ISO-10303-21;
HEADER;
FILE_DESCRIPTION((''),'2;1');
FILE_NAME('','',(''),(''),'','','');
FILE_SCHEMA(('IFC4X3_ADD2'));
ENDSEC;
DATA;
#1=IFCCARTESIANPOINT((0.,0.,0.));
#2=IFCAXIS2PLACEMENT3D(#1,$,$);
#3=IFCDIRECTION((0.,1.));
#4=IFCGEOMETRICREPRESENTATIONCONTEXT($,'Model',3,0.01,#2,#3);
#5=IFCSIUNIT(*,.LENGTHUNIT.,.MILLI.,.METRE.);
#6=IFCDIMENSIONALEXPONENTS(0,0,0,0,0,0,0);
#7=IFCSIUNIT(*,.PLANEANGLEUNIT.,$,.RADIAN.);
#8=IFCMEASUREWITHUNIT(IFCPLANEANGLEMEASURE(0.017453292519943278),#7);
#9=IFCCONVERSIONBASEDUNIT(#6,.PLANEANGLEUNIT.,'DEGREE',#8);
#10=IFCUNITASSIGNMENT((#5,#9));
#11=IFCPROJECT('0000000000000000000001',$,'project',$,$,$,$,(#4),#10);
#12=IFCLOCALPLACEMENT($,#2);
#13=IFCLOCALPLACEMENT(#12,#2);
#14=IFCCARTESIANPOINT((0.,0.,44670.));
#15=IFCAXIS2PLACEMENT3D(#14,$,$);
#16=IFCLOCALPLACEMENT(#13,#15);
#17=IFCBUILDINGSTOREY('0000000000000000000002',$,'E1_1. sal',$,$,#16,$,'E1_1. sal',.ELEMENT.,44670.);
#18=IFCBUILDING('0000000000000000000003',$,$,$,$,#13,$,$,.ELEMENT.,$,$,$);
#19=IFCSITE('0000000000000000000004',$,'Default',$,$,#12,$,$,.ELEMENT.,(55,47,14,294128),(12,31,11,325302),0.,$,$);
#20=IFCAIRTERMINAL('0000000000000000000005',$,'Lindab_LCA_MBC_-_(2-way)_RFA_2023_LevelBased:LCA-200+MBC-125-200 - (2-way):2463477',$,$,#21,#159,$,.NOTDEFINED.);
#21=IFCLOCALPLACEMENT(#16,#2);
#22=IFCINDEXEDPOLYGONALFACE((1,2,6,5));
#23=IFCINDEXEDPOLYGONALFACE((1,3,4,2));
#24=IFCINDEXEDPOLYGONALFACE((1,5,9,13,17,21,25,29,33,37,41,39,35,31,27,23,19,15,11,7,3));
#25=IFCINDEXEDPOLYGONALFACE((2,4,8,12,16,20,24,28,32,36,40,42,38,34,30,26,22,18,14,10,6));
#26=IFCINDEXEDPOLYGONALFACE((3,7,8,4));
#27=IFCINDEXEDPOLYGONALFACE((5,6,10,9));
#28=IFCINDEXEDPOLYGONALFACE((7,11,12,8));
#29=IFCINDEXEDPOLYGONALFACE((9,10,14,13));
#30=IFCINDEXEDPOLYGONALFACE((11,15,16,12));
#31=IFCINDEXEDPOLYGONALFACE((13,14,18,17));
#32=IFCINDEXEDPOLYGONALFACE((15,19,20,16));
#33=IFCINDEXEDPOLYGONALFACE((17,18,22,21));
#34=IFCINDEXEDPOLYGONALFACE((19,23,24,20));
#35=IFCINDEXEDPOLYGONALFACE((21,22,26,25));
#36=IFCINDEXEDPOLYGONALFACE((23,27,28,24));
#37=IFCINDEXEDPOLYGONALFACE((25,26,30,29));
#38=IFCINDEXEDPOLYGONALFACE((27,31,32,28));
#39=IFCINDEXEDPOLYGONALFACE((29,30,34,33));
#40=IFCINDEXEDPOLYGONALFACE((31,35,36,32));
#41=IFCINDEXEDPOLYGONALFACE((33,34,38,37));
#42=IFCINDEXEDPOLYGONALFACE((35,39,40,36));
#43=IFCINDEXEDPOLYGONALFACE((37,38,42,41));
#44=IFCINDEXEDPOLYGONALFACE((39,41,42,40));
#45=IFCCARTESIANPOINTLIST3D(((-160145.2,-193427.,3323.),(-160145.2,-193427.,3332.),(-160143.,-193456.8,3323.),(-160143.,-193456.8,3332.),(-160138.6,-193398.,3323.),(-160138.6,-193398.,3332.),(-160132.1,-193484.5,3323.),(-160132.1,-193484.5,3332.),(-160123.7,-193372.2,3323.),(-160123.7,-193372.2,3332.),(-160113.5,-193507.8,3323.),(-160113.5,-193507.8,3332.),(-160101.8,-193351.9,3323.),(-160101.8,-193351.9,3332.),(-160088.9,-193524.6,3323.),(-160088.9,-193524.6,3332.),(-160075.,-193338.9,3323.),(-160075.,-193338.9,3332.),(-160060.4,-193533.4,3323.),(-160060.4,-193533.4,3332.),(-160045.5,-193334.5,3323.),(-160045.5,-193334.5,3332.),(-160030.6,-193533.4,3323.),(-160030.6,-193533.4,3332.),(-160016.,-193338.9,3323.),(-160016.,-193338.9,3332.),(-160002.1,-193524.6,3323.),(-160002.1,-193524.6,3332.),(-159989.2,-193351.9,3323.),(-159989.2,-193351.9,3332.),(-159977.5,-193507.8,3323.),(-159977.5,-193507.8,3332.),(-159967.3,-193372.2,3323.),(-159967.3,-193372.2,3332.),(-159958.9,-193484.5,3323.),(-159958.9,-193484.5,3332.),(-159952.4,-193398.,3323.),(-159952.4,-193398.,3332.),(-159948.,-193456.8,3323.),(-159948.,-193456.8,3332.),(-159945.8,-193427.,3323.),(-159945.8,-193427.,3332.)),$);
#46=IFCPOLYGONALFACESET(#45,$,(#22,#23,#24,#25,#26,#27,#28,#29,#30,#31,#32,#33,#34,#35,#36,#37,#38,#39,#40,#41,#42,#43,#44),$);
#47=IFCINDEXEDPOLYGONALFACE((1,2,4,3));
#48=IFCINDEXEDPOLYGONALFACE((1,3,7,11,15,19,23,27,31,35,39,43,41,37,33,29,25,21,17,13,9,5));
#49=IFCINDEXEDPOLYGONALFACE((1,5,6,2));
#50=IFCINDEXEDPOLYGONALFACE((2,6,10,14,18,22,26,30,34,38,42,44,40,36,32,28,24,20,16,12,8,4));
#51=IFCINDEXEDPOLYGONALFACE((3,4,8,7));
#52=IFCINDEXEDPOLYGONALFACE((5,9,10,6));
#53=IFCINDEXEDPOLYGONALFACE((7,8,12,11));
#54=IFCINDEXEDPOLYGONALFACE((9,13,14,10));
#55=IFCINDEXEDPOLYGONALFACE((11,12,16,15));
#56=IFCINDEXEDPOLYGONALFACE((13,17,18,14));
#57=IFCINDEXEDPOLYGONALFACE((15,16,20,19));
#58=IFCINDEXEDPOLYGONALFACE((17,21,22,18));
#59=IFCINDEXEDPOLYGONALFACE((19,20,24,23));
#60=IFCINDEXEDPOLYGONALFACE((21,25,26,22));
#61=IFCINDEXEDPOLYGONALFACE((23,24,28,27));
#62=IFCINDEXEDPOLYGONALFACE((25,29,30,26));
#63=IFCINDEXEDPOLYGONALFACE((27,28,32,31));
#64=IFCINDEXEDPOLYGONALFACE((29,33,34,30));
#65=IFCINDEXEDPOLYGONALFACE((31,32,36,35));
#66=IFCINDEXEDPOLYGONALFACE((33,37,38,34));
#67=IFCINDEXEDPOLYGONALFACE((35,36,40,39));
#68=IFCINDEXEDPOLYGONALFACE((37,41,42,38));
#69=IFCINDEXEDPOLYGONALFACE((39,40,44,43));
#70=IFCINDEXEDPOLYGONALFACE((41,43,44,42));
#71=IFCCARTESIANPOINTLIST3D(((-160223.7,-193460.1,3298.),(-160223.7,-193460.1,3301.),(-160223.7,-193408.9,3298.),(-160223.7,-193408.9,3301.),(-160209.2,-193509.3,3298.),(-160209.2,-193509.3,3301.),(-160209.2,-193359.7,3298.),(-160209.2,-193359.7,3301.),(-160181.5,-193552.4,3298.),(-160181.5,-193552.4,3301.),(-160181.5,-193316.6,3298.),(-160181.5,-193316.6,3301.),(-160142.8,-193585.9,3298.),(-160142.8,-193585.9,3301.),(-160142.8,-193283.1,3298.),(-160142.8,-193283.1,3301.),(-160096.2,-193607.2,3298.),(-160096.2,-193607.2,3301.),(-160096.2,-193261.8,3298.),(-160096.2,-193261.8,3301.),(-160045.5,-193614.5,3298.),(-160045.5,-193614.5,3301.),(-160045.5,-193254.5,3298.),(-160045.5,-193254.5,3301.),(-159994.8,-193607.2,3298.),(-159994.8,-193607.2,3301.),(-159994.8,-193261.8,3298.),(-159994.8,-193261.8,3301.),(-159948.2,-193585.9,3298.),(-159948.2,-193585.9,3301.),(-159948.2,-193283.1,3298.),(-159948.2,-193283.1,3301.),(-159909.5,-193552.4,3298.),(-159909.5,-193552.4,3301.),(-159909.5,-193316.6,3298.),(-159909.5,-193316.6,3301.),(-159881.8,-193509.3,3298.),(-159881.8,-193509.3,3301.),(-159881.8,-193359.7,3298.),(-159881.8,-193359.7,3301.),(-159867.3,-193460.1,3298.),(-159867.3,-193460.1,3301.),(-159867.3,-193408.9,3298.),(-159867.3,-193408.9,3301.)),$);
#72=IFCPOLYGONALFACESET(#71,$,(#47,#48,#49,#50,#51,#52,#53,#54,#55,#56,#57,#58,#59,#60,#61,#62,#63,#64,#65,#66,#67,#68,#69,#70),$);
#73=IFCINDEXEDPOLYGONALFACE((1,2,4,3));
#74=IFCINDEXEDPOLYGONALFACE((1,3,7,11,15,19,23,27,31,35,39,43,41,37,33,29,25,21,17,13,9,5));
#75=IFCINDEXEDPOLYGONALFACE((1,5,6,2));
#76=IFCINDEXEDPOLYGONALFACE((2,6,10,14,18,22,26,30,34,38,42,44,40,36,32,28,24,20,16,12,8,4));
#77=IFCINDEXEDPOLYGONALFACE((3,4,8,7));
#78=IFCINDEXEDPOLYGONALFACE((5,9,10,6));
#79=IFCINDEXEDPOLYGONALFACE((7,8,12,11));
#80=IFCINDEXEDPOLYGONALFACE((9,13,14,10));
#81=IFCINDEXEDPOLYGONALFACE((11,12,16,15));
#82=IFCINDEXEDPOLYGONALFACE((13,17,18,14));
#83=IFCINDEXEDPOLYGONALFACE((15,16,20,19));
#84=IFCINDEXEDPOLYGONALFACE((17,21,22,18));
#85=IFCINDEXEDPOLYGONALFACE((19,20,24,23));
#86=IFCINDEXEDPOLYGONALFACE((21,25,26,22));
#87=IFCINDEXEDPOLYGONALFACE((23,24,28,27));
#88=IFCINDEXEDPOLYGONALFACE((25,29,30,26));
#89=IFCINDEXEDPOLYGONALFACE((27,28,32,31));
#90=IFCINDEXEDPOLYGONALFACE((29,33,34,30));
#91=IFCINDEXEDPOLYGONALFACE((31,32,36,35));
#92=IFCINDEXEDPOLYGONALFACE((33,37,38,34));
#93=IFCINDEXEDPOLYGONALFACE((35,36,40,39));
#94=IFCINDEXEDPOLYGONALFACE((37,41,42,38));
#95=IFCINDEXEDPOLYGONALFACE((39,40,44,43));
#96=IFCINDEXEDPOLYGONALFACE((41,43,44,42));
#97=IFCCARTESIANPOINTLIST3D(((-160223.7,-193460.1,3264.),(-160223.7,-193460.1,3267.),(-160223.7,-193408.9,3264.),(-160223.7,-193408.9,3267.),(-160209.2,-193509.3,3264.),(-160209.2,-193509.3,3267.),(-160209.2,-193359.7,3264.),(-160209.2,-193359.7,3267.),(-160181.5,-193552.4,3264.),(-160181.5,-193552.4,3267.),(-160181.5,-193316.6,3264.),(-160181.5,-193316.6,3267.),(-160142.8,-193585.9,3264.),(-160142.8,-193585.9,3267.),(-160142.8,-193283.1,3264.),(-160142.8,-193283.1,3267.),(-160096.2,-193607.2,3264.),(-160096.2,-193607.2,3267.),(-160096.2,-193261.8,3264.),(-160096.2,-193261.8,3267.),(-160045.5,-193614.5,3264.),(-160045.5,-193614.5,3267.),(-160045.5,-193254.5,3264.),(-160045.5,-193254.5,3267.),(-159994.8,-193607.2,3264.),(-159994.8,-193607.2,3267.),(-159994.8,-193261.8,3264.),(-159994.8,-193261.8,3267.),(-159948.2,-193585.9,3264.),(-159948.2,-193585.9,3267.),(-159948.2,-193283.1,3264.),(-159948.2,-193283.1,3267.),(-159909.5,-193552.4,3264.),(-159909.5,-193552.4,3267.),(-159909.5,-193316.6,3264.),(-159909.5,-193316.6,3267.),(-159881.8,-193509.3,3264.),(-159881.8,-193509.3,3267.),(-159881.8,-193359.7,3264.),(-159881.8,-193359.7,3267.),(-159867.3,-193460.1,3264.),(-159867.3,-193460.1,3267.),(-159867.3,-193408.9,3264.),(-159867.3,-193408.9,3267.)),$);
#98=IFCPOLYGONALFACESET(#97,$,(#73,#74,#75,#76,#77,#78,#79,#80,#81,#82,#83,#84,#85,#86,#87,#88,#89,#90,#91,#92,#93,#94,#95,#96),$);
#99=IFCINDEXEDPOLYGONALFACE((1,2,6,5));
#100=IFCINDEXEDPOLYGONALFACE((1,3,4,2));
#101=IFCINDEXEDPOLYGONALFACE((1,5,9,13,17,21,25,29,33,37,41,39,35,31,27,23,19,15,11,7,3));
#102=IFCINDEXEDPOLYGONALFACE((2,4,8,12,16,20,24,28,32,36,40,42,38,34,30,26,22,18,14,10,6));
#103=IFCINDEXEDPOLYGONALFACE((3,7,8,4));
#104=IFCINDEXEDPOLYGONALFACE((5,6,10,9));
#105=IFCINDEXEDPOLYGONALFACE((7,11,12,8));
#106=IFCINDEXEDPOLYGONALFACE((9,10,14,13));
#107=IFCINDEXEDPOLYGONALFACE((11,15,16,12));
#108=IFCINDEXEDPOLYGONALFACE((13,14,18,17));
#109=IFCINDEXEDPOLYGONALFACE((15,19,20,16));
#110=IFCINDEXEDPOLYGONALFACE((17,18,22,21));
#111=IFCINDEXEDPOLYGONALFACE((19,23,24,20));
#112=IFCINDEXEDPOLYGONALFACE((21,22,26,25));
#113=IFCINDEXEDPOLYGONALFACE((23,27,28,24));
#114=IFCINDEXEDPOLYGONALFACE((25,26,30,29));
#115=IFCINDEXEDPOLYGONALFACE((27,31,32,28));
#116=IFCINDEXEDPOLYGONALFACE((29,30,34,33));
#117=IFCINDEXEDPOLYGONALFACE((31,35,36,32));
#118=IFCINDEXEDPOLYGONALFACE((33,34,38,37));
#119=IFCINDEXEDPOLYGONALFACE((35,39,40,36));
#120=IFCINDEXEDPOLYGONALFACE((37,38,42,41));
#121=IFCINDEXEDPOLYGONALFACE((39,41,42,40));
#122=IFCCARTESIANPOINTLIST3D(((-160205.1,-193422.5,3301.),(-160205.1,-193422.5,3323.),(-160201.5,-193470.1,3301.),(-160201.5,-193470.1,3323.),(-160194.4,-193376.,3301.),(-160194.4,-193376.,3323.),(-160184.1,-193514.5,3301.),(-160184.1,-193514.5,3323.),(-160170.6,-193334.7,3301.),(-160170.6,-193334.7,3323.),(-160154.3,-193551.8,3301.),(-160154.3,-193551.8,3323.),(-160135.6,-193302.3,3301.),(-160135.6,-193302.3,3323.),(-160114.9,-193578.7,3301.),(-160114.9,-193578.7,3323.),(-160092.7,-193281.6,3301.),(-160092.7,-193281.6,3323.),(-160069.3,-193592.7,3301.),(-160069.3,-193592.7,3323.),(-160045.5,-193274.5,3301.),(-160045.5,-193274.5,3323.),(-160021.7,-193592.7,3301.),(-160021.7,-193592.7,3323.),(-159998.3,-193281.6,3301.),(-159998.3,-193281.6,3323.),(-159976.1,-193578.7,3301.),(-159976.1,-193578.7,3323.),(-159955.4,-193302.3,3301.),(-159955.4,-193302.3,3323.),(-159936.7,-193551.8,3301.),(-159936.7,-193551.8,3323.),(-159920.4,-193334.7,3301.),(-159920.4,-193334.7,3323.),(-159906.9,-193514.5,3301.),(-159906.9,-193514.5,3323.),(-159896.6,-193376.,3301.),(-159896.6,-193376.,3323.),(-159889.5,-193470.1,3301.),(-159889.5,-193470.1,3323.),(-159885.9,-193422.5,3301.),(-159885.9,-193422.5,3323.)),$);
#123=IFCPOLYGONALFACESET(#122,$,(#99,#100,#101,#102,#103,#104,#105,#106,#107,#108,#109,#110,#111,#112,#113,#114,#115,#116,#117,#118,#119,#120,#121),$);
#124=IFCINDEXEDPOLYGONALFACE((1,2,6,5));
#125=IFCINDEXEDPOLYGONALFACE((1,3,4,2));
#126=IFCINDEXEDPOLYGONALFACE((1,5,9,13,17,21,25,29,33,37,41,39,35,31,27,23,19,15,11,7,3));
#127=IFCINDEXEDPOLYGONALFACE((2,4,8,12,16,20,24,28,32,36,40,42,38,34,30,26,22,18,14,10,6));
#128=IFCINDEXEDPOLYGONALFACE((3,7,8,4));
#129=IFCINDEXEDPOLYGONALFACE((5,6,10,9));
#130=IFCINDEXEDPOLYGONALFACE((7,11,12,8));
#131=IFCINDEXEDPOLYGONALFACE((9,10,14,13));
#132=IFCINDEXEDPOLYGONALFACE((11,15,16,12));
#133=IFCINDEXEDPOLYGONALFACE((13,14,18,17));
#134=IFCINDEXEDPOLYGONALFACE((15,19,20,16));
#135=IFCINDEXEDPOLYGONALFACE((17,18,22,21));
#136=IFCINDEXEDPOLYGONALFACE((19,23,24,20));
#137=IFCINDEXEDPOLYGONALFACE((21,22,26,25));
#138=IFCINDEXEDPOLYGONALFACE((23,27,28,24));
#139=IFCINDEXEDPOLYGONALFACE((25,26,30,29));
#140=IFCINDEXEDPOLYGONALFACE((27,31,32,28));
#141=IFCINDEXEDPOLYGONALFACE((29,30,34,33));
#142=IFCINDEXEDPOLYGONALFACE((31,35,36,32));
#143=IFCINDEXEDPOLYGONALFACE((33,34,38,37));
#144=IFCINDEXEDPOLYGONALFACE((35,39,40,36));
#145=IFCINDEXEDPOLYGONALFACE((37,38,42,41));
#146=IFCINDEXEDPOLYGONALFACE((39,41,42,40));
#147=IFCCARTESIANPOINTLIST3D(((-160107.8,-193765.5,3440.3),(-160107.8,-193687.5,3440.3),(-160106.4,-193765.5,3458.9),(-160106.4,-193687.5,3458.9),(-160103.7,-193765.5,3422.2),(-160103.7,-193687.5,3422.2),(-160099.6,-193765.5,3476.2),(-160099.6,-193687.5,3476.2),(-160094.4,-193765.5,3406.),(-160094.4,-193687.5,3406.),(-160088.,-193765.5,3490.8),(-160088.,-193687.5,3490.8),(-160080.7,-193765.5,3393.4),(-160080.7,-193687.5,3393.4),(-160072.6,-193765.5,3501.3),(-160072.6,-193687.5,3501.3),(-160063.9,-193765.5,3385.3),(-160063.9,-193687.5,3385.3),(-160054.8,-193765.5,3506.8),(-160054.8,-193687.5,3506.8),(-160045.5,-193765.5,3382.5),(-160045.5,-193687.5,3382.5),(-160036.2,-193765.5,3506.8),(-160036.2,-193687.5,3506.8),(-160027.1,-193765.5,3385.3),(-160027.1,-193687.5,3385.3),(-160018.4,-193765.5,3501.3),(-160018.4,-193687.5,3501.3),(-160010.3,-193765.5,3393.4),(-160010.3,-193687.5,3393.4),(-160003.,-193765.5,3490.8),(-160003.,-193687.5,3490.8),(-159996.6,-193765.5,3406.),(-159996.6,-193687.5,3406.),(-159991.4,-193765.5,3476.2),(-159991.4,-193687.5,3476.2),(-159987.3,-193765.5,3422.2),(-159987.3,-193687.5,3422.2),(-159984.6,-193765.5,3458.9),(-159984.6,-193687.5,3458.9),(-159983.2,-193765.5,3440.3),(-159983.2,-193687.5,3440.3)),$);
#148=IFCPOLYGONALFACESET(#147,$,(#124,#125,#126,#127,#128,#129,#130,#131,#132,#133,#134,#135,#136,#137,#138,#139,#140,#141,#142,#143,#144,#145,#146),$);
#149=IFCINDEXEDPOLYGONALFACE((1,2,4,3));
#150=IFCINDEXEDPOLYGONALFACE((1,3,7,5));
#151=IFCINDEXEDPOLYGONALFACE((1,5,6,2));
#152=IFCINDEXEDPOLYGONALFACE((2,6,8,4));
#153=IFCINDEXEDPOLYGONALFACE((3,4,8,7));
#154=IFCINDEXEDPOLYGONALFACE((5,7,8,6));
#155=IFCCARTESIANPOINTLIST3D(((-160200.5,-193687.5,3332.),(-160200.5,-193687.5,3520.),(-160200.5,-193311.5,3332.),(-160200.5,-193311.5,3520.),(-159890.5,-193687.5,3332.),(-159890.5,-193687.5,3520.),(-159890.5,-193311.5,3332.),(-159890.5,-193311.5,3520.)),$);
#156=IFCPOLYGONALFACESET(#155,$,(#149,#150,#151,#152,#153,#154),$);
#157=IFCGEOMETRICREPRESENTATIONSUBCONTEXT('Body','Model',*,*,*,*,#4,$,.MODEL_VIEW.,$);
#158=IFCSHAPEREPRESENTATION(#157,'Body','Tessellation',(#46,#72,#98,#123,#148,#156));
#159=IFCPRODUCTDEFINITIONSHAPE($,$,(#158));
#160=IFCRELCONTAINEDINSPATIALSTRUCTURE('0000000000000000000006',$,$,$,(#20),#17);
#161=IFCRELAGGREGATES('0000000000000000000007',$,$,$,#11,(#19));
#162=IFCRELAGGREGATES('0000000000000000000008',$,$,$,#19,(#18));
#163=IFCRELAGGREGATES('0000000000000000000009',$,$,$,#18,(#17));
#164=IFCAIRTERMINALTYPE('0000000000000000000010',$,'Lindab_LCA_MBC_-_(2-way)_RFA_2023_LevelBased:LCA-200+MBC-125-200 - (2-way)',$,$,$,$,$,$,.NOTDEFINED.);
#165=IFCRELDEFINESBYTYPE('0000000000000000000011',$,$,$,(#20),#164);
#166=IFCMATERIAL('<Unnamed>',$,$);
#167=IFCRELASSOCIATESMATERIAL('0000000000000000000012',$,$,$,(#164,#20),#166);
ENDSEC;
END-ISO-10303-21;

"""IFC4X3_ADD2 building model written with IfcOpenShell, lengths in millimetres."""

from ifc_helpers import new_model, entity, si_unit, converted_unit, direction, frame, frame_2d, origin, origin_2d_with_axis, place, context, subcontext, project, spatial, rectangle, circle, extrude, source, transform, mapped, material, type_object, type_shapes, element, save


model = new_model("IFC4X3_ADD2")

# Units and contexts
model_context = context("Model", 3, precision=0.01, world=origin(), true_north=direction((0.0, 1.0)))
body_context = subcontext(model_context, "Body", "Model", "MODEL_VIEW")
ifc_project = project(units=[si_unit("LENGTHUNIT", "METRE", prefix="MILLI"), converted_unit("PLANEANGLEUNIT", "DEGREE", entity("IfcPlaneAngleMeasure", 0.017453292519943278), si_unit("PLANEANGLEUNIT", "RADIAN"), dimensions=[0, 0, 0, 0, 0, 0, 0])], contexts=[model_context])

# Site, building, storey
site_placement = place(None, origin())
site = spatial("IfcSite", under=ifc_project, at=site_placement, Name="Default", CompositionType="ELEMENT", RefLatitude=(55, 47, 14, 294128), RefLongitude=(12, 31, 11, 325302), RefElevation=0.0)
building_placement = place(site_placement, origin())
building = spatial("IfcBuilding", under=site, at=building_placement, CompositionType="ELEMENT")
storey_placement = place(building_placement, frame((0.0, 0.0, 44670.0)))
storey = spatial("IfcBuildingStorey", under=building, at=storey_placement, Name="E1_1. sal", LongName="E1_1. sal", CompositionType="ELEMENT", Elevation=44670.0)

# Air terminal
ifc_material_1 = material(Name="<Unnamed>")
air_terminal_type_1 = type_object("IfcAirTerminalType", Name="Lindab_LCA_MBC_-_(2-way)_RFA_2023_LevelBased:LCA-200+MBC-125-200 - (2-way)", PredefinedType="NOTDEFINED", material=ifc_material_1)
shared_shape_1 = source(origin(), body_context, "Body", "SweptSolid", [
    extrude(circle(Radius=100.0, at=frame_2d((0.0, 0.0), x_axis=(1.0, 0.0))), frame((0.0, 0.0, 22.0)), (0.0, 0.0, 1.0), 9.0),
    extrude(circle(Radius=180.0, at=frame_2d((0.0, 0.0), x_axis=(1.0, 0.0))), frame((0.0, 0.0, -3.0)), (0.0, 0.0, 1.0), 3.0),
    extrude(circle(Radius=180.0, at=frame_2d((0.0, 0.0), x_axis=(1.0, 0.0))), frame((0.0, 0.0, -37.0)), (0.0, 0.0, 1.0), 3.0),
    extrude(circle(Radius=160.0, at=frame_2d((0.0, 0.0), x_axis=(1.0, 0.0))), origin(), (0.0, 0.0, 1.0), 22.0),
    extrude(circle(Radius=62.5, at=frame_2d((0.0, 0.0), x_axis=(1.0, 0.0))), frame((-331.0, 0.0, 144.0), z_axis=(1.0, 0.0, 0.0), x_axis=(0.0, 0.0, -1.0)), (0.0, 0.0, 1.0), 78.0),
    extrude(rectangle(XDim=310.0, YDim=376.0, at=origin_2d_with_axis()), frame((-65.0, 0.0, 31.0), z_axis=(0.0, 0.0, 1.0), x_axis=(0.0, -1.0, 0.0)), (0.0, 0.0, 1.0), 188.0),
])
type_shapes(air_terminal_type_1, [shared_shape_1])
for number, where, z_axis, x_axis, name in (
    (1, (-160045.5, -193434.5, 3301.0), (0.0, 0.0, 1.0), (0.0, 1.0, 0.0), "Lindab_LCA_MBC_-_(2-way)_RFA_2023_LevelBased:LCA-200+MBC-125-200 - (2-way):2463477"),
):
    element("IfcAirTerminal", number, at=place(storey_placement, frame(where, z_axis=z_axis, x_axis=x_axis)), inside=storey, type_object=air_terminal_type_1, material=ifc_material_1, Name=name, PredefinedType="NOTDEFINED", context=body_context, shape_type="MappedRepresentation", body=[
        mapped(shared_shape_1, transform((0.0, 0.0, 0.0), scale=1.0)),
    ])

save(model, "model.ifc")
